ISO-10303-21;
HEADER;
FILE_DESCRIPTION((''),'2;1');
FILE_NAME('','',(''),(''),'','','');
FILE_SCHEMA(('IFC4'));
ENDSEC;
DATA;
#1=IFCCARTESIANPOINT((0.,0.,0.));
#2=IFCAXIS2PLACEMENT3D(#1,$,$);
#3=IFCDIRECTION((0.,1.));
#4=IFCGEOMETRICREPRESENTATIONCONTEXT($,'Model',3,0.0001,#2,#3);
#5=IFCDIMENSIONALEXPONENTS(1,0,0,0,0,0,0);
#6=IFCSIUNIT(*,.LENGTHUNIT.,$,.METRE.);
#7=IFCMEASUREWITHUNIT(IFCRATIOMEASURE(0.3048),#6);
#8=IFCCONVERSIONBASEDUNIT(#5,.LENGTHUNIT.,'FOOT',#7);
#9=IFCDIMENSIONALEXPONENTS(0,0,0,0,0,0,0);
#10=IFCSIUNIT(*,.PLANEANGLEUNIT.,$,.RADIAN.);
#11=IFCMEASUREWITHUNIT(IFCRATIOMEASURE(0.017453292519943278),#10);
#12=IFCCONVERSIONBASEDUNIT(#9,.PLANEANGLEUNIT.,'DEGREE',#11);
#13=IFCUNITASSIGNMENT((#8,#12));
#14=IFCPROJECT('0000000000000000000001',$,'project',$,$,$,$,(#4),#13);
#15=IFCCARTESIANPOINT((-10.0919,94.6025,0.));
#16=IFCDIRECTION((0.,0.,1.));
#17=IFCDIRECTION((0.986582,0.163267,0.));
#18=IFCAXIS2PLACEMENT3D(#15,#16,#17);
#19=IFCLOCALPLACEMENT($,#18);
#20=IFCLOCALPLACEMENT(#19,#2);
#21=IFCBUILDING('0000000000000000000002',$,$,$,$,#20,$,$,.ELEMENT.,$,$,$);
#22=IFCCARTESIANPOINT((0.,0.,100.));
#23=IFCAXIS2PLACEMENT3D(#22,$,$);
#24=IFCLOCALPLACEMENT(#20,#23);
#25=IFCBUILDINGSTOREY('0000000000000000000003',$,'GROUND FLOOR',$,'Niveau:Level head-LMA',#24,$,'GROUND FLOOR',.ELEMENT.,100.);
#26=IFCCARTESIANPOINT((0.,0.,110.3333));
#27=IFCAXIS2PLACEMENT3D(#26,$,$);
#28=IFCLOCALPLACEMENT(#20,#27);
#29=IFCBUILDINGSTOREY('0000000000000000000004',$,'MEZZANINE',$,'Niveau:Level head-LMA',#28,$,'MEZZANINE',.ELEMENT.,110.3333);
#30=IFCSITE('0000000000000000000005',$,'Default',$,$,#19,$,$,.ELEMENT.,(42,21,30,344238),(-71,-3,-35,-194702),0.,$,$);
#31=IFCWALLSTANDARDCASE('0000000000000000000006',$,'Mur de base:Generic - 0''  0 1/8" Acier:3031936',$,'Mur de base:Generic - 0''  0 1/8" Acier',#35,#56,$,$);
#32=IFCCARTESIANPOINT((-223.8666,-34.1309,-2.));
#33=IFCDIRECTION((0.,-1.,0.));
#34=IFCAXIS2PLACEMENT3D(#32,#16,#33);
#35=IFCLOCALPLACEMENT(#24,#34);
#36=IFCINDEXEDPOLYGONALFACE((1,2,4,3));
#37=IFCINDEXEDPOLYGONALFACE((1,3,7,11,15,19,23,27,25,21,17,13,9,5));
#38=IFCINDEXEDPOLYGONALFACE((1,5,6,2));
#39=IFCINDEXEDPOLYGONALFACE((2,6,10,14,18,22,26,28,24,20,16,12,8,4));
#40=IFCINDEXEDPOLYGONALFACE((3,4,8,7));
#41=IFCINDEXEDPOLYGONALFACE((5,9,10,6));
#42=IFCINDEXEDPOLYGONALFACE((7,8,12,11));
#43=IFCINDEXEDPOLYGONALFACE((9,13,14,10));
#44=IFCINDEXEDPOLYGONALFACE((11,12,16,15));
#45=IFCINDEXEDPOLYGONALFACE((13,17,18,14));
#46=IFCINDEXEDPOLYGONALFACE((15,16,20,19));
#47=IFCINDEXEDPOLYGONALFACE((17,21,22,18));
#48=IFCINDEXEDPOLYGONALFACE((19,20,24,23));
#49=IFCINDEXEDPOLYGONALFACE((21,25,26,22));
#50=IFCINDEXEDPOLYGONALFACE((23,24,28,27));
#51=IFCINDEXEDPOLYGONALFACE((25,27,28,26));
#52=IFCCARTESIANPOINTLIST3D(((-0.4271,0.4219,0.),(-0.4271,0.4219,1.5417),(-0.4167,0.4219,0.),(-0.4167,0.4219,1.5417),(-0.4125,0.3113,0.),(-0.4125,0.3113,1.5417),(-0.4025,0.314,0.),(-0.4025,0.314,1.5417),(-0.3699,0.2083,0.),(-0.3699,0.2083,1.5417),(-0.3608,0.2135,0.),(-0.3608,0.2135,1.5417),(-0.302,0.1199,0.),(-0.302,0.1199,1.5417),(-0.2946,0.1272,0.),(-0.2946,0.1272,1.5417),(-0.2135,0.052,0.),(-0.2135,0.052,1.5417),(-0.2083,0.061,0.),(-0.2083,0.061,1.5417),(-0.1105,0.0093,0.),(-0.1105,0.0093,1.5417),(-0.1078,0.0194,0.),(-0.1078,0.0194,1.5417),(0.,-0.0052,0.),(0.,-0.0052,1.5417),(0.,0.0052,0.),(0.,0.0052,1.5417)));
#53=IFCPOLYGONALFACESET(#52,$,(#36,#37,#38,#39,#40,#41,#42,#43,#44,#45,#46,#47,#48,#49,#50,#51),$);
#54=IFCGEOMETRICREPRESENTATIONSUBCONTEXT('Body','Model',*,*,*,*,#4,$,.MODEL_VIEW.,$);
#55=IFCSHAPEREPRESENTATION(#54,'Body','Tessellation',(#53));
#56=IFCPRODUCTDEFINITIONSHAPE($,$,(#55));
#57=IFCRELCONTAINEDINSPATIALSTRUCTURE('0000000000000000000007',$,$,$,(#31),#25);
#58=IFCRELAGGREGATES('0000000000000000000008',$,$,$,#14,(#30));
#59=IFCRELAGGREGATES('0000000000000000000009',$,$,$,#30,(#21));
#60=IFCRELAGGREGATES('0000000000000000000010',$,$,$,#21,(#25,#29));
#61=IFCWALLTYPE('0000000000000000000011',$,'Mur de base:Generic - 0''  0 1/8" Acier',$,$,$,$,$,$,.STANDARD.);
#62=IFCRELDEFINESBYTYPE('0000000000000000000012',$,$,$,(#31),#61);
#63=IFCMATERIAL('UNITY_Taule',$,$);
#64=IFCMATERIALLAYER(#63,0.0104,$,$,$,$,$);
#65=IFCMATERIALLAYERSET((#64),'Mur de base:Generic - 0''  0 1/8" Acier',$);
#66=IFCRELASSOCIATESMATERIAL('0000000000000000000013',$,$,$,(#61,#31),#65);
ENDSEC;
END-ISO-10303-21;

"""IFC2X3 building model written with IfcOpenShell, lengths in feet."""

from ifc_helpers import new_model, entity, si_unit, converted_unit, direction, frame, frame_2d, origin, place, context, subcontext, project, spatial, polyline, circle_curve, parameter, trimmed, segment, composite_curve, outline, extrude, material, layer, layer_set, layer_usage, type_object, element, save


model = new_model("IFC2X3")

# Units and contexts
model_context = context("Model", 3, precision=0.0001, world=origin(), true_north=direction((0.0, 1.0)))
body_context = subcontext(model_context, "Body", "Model", "MODEL_VIEW")
ifc_project = project(units=[converted_unit("LENGTHUNIT", "FOOT", entity("IfcRatioMeasure", 0.3048), si_unit("LENGTHUNIT", "METRE"), dimensions=[1, 0, 0, 0, 0, 0, 0]), converted_unit("PLANEANGLEUNIT", "DEGREE", entity("IfcRatioMeasure", 0.017453292519943278), si_unit("PLANEANGLEUNIT", "RADIAN"), dimensions=[0, 0, 0, 0, 0, 0, 0])], contexts=[model_context])

# Site, building, storey
site_placement = place(None, frame((-10.0919, 94.6025, 0.0), z_axis=(0.0, 0.0, 1.0), x_axis=(0.986582, 0.163267, 0.0)))
site = spatial("IfcSite", under=ifc_project, at=site_placement, Name="Default", CompositionType="ELEMENT", RefLatitude=(42, 21, 30, 344238), RefLongitude=(-71, -3, -35, -194702), RefElevation=0.0)
building_placement = place(site_placement, origin())
building = spatial("IfcBuilding", under=site, at=building_placement, CompositionType="ELEMENT")
storey_1_placement = place(building_placement, frame((0.0, 0.0, 100.0)))
storey_1 = spatial("IfcBuildingStorey", under=building, at=storey_1_placement, Name="GROUND FLOOR", ObjectType="Niveau:Level head-LMA", LongName="GROUND FLOOR", CompositionType="ELEMENT", Elevation=100.0)

# Shared definitions
storey_2_placement = place(building_placement, frame((0.0, 0.0, 110.3333)))
storey_2 = spatial("IfcBuildingStorey", under=building, at=storey_2_placement, Name="MEZZANINE", ObjectType="Niveau:Level head-LMA", LongName="MEZZANINE", CompositionType="ELEMENT", Elevation=110.3333)

# Wall
ifc_material_1 = material(Name="UNITY_Taule")
ifc_layer_1 = layer(ifc_material_1, 0.0104)
ifc_layer_set_1 = layer_set([ifc_layer_1], Name="Mur de base:Generic - 0'  0 1/8\" Acier")
wall_type_1 = type_object("IfcWallType", Name="Mur de base:Generic - 0'  0 1/8\" Acier", PredefinedType="STANDARD", material=ifc_layer_set_1)
ifc_layer_usage_1 = layer_usage(ifc_layer_set_1, "AXIS2", "NEGATIVE", 0.0052)
wall_1_placement = place(storey_1_placement, frame((-223.8666, -34.1309, -2.0), z_axis=(0.0, 0.0, 1.0), x_axis=(0.0, -1.0, 0.0)))
element("IfcWallStandardCase", 1, at=wall_1_placement, inside=storey_1, type_object=wall_type_1, material=ifc_layer_usage_1, Name="Mur de base:Generic - 0'  0 1/8\" Acier:3031936", ObjectType="Mur de base:Generic - 0'  0 1/8\" Acier", context=body_context, shape_type="SweptSolid", body=[
    extrude(outline(composite_curve([segment(trimmed(circle_curve(frame_2d((0.0, 0.4219), x_axis=(1.0, 0.0)), 0.4271), [parameter(180.0)], [parameter(270.0)], True, "PARAMETER"), True, "CONTINUOUS"), segment(polyline([(0.0, -0.0052), (0.0, 0.0052)]), True, "CONTINUOUS"), segment(trimmed(circle_curve(frame_2d((0.0, 0.4219), x_axis=(1.0, 0.0)), 0.4167), [parameter(180.0)], [parameter(270.0)], True, "PARAMETER"), False, "CONTINUOUS"), segment(polyline([(-0.4167, 0.4219), (-0.4271, 0.4219)]), True, "CONTINUOUS")], self_intersect=False)), origin(), (0.0, 0.0, 1.0), 1.5417),
])

save(model, "model.ifc")
